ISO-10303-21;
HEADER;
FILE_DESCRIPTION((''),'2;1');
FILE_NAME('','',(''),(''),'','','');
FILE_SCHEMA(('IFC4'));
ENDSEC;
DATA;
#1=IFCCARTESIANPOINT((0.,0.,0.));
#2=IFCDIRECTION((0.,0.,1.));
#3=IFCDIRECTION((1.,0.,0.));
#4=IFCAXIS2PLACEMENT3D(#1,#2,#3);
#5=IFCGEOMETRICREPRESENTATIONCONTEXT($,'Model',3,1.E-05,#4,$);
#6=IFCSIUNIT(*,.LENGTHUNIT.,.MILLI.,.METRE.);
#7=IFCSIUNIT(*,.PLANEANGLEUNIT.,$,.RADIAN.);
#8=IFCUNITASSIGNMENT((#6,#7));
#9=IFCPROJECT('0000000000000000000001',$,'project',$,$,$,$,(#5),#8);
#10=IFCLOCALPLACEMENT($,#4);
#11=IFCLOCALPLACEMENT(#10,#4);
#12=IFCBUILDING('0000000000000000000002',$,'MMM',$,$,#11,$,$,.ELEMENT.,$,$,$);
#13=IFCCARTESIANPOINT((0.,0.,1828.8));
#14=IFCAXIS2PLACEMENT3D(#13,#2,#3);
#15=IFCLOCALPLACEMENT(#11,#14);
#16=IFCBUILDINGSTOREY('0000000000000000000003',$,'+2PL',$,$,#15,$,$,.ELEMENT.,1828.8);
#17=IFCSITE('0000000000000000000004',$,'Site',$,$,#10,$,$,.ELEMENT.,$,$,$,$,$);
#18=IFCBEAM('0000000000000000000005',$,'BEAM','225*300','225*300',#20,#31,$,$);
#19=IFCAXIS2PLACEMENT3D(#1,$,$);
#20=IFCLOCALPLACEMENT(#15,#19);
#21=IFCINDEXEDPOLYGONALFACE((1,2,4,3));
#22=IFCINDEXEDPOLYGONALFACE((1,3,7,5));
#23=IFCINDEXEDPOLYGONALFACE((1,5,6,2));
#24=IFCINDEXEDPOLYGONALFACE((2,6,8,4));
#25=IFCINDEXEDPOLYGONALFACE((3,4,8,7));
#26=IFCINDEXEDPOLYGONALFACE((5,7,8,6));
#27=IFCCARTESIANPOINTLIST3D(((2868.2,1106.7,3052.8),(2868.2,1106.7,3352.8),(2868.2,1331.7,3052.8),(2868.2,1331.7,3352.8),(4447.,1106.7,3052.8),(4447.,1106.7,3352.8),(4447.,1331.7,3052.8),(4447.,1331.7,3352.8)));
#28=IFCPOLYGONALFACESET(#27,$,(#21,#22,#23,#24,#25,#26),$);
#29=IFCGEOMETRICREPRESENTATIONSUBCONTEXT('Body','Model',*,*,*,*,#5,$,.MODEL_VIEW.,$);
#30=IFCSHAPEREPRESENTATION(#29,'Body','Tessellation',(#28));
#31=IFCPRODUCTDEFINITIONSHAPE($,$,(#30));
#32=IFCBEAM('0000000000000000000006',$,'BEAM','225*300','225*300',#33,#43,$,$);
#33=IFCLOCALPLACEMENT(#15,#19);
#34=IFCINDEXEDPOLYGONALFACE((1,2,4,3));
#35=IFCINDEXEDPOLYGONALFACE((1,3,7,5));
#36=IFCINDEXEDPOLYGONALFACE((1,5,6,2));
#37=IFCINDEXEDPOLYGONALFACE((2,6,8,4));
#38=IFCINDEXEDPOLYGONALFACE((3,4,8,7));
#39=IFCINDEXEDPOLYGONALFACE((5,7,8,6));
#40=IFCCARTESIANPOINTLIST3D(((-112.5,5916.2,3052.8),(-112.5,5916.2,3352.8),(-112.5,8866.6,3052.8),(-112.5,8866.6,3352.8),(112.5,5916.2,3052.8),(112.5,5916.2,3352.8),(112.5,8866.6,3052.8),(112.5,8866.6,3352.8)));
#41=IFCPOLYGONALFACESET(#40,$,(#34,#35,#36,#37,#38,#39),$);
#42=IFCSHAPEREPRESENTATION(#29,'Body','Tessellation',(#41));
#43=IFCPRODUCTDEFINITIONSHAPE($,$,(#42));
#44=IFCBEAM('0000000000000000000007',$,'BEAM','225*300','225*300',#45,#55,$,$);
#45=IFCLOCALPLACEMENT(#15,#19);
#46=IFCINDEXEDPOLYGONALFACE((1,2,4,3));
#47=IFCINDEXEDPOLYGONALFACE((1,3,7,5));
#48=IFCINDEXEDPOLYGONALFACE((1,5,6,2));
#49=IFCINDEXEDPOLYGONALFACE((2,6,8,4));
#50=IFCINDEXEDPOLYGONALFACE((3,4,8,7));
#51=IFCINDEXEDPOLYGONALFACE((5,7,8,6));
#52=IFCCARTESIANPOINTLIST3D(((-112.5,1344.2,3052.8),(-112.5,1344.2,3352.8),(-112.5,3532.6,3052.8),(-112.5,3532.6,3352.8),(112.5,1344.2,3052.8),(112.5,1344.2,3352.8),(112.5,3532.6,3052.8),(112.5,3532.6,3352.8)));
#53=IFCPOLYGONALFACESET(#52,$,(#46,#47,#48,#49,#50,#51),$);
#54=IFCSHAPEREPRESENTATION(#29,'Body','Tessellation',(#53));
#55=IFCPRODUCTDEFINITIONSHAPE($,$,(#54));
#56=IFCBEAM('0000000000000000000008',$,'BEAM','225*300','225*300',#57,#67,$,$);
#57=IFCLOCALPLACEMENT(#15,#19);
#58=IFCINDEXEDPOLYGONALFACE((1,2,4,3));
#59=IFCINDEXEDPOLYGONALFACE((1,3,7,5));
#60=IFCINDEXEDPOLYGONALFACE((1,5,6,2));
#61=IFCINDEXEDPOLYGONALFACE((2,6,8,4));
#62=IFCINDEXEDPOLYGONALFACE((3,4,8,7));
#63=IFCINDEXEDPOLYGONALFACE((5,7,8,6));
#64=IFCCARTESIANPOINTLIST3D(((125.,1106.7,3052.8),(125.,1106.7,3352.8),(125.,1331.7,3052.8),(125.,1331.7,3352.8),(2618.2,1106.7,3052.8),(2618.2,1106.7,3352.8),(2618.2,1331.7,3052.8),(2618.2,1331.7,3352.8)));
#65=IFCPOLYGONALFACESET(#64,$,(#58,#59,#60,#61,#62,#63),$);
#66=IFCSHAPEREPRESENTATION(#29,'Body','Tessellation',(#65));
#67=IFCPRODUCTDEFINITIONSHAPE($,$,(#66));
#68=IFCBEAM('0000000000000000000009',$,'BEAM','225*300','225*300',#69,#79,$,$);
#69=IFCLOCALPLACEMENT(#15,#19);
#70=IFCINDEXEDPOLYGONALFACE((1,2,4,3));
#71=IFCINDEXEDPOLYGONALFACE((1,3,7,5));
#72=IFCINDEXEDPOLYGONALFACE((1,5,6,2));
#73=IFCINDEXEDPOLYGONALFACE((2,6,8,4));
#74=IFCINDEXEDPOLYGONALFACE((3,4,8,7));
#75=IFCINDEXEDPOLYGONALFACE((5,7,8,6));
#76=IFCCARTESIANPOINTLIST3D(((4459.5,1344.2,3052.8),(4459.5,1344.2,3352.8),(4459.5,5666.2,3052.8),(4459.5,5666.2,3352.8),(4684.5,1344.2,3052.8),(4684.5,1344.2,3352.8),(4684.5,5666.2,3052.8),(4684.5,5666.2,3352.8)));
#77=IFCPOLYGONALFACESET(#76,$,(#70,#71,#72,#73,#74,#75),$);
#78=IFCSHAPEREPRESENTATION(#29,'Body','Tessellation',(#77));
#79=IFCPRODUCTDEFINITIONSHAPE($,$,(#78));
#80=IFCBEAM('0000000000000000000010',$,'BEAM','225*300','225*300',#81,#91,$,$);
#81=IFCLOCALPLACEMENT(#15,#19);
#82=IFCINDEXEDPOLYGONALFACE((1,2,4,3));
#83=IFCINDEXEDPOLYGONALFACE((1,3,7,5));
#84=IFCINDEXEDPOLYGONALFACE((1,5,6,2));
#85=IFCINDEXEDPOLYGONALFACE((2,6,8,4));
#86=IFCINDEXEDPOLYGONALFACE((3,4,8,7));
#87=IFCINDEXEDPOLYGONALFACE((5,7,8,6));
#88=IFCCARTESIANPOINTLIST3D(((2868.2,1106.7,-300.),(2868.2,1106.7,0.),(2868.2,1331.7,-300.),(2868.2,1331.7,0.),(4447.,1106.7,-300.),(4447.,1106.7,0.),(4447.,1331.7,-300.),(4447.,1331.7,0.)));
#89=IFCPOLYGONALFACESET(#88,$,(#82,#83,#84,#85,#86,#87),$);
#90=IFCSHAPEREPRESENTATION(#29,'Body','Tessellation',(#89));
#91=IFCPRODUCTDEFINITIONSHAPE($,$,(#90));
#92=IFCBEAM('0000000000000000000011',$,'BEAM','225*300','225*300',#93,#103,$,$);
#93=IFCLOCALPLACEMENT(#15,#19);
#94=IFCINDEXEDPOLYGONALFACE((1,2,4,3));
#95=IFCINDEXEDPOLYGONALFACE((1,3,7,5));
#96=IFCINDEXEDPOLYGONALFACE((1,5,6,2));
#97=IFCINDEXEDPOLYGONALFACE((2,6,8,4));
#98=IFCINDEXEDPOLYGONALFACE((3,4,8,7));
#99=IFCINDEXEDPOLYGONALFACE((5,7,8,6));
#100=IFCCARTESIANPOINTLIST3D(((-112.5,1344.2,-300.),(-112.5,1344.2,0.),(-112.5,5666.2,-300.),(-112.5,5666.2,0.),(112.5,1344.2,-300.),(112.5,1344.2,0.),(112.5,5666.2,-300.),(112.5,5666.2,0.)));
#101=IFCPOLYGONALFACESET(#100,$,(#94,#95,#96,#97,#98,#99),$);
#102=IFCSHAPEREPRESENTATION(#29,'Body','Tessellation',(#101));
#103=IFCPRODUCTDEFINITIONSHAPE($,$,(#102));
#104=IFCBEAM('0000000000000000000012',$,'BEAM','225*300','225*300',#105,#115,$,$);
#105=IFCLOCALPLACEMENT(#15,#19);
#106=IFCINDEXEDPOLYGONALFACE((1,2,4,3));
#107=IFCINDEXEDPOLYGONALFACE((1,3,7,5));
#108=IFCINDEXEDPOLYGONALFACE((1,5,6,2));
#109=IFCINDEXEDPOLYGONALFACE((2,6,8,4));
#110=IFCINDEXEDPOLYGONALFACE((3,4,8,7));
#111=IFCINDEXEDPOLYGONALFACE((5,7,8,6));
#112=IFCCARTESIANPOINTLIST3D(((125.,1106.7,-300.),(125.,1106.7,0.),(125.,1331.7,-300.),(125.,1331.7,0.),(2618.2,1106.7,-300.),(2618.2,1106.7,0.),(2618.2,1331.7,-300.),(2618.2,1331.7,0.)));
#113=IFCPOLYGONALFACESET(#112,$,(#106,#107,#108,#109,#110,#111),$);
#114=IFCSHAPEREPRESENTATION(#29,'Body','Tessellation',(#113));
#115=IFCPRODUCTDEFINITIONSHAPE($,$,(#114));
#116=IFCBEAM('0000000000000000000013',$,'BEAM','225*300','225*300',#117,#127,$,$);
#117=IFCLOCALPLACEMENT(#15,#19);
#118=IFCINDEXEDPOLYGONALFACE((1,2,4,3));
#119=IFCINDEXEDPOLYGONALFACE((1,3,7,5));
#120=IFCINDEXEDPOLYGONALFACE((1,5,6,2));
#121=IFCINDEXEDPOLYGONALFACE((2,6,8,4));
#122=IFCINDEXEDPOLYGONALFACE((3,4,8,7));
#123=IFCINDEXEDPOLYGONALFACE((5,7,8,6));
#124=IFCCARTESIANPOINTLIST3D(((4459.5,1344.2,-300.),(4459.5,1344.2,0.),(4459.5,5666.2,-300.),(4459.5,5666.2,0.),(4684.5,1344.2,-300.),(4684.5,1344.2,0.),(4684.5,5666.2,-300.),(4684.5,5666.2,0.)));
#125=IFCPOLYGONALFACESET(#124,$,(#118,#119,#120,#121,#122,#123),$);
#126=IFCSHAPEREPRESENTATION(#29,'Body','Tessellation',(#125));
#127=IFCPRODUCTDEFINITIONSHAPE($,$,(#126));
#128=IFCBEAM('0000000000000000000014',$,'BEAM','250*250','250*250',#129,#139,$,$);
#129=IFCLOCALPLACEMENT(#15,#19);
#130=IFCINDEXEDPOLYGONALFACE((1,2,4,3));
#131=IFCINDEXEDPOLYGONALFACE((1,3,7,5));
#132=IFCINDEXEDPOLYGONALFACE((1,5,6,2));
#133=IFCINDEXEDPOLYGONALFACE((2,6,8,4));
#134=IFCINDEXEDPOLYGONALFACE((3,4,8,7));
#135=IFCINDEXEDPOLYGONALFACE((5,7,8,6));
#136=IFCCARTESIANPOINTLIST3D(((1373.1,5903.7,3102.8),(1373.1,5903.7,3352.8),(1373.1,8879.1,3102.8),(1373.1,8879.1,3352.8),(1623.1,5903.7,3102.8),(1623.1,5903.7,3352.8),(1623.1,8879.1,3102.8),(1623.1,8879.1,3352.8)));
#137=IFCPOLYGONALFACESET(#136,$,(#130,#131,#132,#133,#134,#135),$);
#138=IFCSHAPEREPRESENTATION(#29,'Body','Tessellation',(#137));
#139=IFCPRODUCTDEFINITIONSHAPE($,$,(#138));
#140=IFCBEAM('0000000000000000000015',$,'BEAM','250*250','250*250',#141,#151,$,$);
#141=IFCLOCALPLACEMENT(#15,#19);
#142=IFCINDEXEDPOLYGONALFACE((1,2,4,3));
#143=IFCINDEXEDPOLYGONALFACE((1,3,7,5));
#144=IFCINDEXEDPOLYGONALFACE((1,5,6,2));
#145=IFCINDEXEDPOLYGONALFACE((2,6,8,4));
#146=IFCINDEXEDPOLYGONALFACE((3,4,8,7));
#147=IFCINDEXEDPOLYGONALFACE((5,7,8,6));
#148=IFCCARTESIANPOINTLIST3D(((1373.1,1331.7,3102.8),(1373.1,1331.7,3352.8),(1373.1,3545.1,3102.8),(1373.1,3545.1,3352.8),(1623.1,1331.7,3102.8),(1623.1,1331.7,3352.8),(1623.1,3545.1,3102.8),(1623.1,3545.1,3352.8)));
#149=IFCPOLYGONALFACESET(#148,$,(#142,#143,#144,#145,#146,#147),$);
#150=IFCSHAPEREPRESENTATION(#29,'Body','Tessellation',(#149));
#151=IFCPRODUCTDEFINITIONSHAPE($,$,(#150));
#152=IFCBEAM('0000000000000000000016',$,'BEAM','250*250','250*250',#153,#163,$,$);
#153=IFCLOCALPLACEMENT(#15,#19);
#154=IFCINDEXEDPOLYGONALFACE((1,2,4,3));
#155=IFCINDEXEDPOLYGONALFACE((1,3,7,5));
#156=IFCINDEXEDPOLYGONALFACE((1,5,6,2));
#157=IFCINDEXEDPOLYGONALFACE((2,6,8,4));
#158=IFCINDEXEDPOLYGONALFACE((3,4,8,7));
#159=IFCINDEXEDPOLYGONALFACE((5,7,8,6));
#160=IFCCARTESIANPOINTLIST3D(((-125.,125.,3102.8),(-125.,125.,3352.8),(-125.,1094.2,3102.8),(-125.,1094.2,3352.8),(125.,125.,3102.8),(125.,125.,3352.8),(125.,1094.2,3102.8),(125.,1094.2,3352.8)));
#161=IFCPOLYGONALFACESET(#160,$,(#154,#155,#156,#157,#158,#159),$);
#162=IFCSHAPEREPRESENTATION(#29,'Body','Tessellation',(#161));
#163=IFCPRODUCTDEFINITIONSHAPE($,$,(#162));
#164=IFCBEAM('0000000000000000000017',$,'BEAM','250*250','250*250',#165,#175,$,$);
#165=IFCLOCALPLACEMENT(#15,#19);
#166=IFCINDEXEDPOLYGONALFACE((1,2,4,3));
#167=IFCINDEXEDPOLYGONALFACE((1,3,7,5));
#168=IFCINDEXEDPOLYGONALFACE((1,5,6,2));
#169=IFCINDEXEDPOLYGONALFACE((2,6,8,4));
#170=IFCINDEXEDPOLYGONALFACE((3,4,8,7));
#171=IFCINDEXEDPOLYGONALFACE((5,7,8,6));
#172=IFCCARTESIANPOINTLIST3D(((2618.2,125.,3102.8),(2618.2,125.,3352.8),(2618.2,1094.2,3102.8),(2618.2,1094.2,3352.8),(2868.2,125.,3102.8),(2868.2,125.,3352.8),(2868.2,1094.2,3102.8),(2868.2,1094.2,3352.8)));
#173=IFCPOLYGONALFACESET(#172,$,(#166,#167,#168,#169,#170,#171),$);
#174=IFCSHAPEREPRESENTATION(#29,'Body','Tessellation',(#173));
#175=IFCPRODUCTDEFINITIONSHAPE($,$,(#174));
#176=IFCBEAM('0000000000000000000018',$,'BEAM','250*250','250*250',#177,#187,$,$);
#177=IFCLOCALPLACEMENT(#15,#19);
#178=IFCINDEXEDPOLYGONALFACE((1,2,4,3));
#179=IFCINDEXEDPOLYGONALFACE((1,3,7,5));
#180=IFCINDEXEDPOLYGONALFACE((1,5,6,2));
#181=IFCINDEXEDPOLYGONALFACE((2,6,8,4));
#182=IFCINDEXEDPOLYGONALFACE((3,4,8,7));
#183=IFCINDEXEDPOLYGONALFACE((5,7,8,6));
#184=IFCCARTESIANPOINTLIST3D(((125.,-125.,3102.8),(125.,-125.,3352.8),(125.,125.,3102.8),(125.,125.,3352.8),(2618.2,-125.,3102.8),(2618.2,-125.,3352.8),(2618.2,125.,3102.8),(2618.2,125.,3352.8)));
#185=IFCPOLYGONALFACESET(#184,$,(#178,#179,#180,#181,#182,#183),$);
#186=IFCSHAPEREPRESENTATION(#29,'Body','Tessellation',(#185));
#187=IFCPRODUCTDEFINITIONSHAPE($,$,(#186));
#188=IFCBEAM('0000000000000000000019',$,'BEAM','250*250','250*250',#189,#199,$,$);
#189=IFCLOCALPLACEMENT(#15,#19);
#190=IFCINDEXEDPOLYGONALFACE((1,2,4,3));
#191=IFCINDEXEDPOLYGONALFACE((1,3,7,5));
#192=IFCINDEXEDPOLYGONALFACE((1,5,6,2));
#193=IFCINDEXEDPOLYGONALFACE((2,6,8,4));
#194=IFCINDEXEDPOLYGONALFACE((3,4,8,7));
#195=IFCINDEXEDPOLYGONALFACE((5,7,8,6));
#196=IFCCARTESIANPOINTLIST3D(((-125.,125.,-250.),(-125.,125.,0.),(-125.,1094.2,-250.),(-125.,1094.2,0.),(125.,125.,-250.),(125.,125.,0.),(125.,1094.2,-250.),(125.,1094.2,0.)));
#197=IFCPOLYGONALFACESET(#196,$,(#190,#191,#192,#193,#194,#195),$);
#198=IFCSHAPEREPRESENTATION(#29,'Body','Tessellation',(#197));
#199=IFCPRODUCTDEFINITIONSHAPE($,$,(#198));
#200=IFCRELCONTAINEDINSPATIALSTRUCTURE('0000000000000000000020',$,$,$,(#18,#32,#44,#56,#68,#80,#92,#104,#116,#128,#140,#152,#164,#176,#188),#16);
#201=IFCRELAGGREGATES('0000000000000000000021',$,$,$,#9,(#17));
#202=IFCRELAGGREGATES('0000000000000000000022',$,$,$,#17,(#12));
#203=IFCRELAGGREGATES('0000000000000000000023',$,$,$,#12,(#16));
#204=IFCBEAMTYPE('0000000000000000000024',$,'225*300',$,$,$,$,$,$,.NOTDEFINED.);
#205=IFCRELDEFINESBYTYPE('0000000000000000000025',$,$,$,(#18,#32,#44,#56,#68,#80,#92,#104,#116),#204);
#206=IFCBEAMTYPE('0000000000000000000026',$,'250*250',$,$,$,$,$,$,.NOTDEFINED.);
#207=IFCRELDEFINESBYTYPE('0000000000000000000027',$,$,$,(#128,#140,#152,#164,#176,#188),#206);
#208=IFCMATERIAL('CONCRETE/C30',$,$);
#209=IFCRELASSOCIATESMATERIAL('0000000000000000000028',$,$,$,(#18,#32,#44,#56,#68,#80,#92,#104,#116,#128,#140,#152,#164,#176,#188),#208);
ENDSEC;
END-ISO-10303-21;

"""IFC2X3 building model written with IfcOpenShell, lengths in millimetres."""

from ifc_helpers import new_model, si_unit, frame, origin_with_axes, origin_2d_with_axis, place, context, subcontext, project, spatial, rectangle, extrude, material, type_object, element, save


model = new_model("IFC2X3")

# Units and contexts
model_context = context("Model", 3, precision=1e-05, world=origin_with_axes())
body_context = subcontext(model_context, "Body", "Model", "MODEL_VIEW")
ifc_project = project(units=[si_unit("LENGTHUNIT", "METRE", prefix="MILLI"), si_unit("PLANEANGLEUNIT", "RADIAN")], contexts=[model_context])

# Site, building, storey
site_placement = place(None, origin_with_axes())
site = spatial("IfcSite", under=ifc_project, at=site_placement, Name="Site", CompositionType="ELEMENT")
building_placement = place(site_placement, origin_with_axes())
building = spatial("IfcBuilding", under=site, at=building_placement, Name="MMM", CompositionType="ELEMENT")
storey_placement = place(building_placement, frame((0.0, 0.0, 1828.8), z_axis=(0.0, 0.0, 1.0), x_axis=(1.0, 0.0, 0.0)))
storey = spatial("IfcBuildingStorey", under=building, at=storey_placement, Name="+2PL", CompositionType="ELEMENT", Elevation=1828.8)

# Shared definitions
ifc_material = material(Name="CONCRETE/C30")

# Beams
beam_type_1 = type_object("IfcBeamType", Name="225*300", PredefinedType="NOTDEFINED")
beam_1_placement = place(storey_placement, frame((2868.2, 1219.2, 3202.8), z_axis=(0.0, 0.0, 1.0), x_axis=(1.0, 0.0, 0.0)))
element("IfcBeam", 1, at=beam_1_placement, inside=storey, type_object=beam_type_1, material=ifc_material, Name="BEAM", Description="225*300", ObjectType="225*300", context=body_context, shape_type="SweptSolid", body=[
    extrude(rectangle(XDim=225.0, YDim=300.0, at=origin_2d_with_axis()), frame((1578.8, 0.0, 0.0), z_axis=(-1.0, 0.0, 0.0), x_axis=(0.0, -1.0, 0.0)), (0.0, 0.0, 1.0), 1578.8),
])
beam_2_placement = place(storey_placement, frame((0.0, 5916.2, 3202.8), z_axis=(0.0, 0.0, 1.0), x_axis=(0.0, 1.0, 0.0)))
element("IfcBeam", 2, at=beam_2_placement, inside=storey, type_object=beam_type_1, material=ifc_material, Name="BEAM", Description="225*300", ObjectType="225*300", context=body_context, shape_type="SweptSolid", body=[
    extrude(rectangle(XDim=225.0, YDim=300.0, at=origin_2d_with_axis()), frame((2950.4, 0.0, 0.0), z_axis=(-1.0, 0.0, 0.0), x_axis=(0.0, -1.0, 0.0)), (0.0, 0.0, 1.0), 2950.4),
])
beam_3_placement = place(storey_placement, frame((0.0, 1344.2, 3202.8), z_axis=(0.0, 0.0, 1.0), x_axis=(0.0, 1.0, 0.0)))
element("IfcBeam", 3, at=beam_3_placement, inside=storey, type_object=beam_type_1, material=ifc_material, Name="BEAM", Description="225*300", ObjectType="225*300", context=body_context, shape_type="SweptSolid", body=[
    extrude(rectangle(XDim=225.0, YDim=300.0, at=origin_2d_with_axis()), frame((2188.4, 0.0, 0.0), z_axis=(-1.0, 0.0, 0.0), x_axis=(0.0, -1.0, 0.0)), (0.0, 0.0, 1.0), 2188.4),
])
beam_4_placement = place(storey_placement, frame((125.0, 1219.2, 3202.8), z_axis=(0.0, 0.0, 1.0), x_axis=(1.0, 0.0, 0.0)))
element("IfcBeam", 4, at=beam_4_placement, inside=storey, type_object=beam_type_1, material=ifc_material, Name="BEAM", Description="225*300", ObjectType="225*300", context=body_context, shape_type="SweptSolid", body=[
    extrude(rectangle(XDim=225.0, YDim=300.0, at=origin_2d_with_axis()), frame((2493.2, 0.0, 0.0), z_axis=(-1.0, 0.0, 0.0), x_axis=(0.0, -1.0, 0.0)), (0.0, 0.0, 1.0), 2493.2),
])
beam_5_placement = place(storey_placement, frame((4572.0, 1344.2, 3202.8), z_axis=(0.0, 0.0, 1.0), x_axis=(0.0, 1.0, 0.0)))
element("IfcBeam", 5, at=beam_5_placement, inside=storey, type_object=beam_type_1, material=ifc_material, Name="BEAM", Description="225*300", ObjectType="225*300", context=body_context, shape_type="SweptSolid", body=[
    extrude(rectangle(XDim=225.0, YDim=300.0, at=origin_2d_with_axis()), frame((4322.0, 0.0, 0.0), z_axis=(-1.0, 0.0, 0.0), x_axis=(0.0, -1.0, 0.0)), (0.0, 0.0, 1.0), 4322.0),
])
beam_6_placement = place(storey_placement, frame((2868.2, 1219.2, -150.0), z_axis=(0.0, 0.0, 1.0), x_axis=(1.0, 0.0, 0.0)))
element("IfcBeam", 6, at=beam_6_placement, inside=storey, type_object=beam_type_1, material=ifc_material, Name="BEAM", Description="225*300", ObjectType="225*300", context=body_context, shape_type="SweptSolid", body=[
    extrude(rectangle(XDim=225.0, YDim=300.0, at=origin_2d_with_axis()), frame((1578.8, 0.0, 0.0), z_axis=(-1.0, 0.0, 0.0), x_axis=(0.0, -1.0, 0.0)), (0.0, 0.0, 1.0), 1578.8),
])
beam_7_placement = place(storey_placement, frame((0.0, 1344.2, -150.0), z_axis=(0.0, 0.0, 1.0), x_axis=(0.0, 1.0, 0.0)))
element("IfcBeam", 7, at=beam_7_placement, inside=storey, type_object=beam_type_1, material=ifc_material, Name="BEAM", Description="225*300", ObjectType="225*300", context=body_context, shape_type="SweptSolid", body=[
    extrude(rectangle(XDim=225.0, YDim=300.0, at=origin_2d_with_axis()), frame((4322.0, 0.0, 0.0), z_axis=(-1.0, 0.0, 0.0), x_axis=(0.0, -1.0, 0.0)), (0.0, 0.0, 1.0), 4322.0),
])
beam_8_placement = place(storey_placement, frame((125.0, 1219.2, -150.0), z_axis=(0.0, 0.0, 1.0), x_axis=(1.0, 0.0, 0.0)))
element("IfcBeam", 8, at=beam_8_placement, inside=storey, type_object=beam_type_1, material=ifc_material, Name="BEAM", Description="225*300", ObjectType="225*300", context=body_context, shape_type="SweptSolid", body=[
    extrude(rectangle(XDim=225.0, YDim=300.0, at=origin_2d_with_axis()), frame((2493.2, 0.0, 0.0), z_axis=(-1.0, 0.0, 0.0), x_axis=(0.0, -1.0, 0.0)), (0.0, 0.0, 1.0), 2493.2),
])
beam_9_placement = place(storey_placement, frame((4572.0, 1344.2, -150.0), z_axis=(0.0, 0.0, 1.0), x_axis=(0.0, 1.0, 0.0)))
element("IfcBeam", 9, at=beam_9_placement, inside=storey, type_object=beam_type_1, material=ifc_material, Name="BEAM", Description="225*300", ObjectType="225*300", context=body_context, shape_type="SweptSolid", body=[
    extrude(rectangle(XDim=225.0, YDim=300.0, at=origin_2d_with_axis()), frame((4322.0, 0.0, 0.0), z_axis=(-1.0, 0.0, 0.0), x_axis=(0.0, -1.0, 0.0)), (0.0, 0.0, 1.0), 4322.0),
])
beam_type_2 = type_object("IfcBeamType", Name="250*250", PredefinedType="NOTDEFINED")
beam_10_placement = place(storey_placement, frame((1498.1, 5903.7, 3227.8), z_axis=(0.0, 0.0, 1.0), x_axis=(0.0, 1.0, 0.0)))
element("IfcBeam", 10, at=beam_10_placement, inside=storey, type_object=beam_type_2, material=ifc_material, Name="BEAM", Description="250*250", ObjectType="250*250", context=body_context, shape_type="SweptSolid", body=[
    extrude(rectangle(XDim=250.0, YDim=250.0, at=origin_2d_with_axis()), frame((2975.4, 0.0, 0.0), z_axis=(-1.0, 0.0, 0.0), x_axis=(0.0, -1.0, 0.0)), (0.0, 0.0, 1.0), 2975.4),
])
beam_11_placement = place(storey_placement, frame((1498.1, 1331.7, 3227.8), z_axis=(0.0, 0.0, 1.0), x_axis=(0.0, 1.0, 0.0)))
element("IfcBeam", 11, at=beam_11_placement, inside=storey, type_object=beam_type_2, material=ifc_material, Name="BEAM", Description="250*250", ObjectType="250*250", context=body_context, shape_type="SweptSolid", body=[
    extrude(rectangle(XDim=250.0, YDim=250.0, at=origin_2d_with_axis()), frame((2213.4, 0.0, 0.0), z_axis=(-1.0, 0.0, 0.0), x_axis=(0.0, -1.0, 0.0)), (0.0, 0.0, 1.0), 2213.4),
])
for number, where, z_axis, x_axis, name in (
    (12, (0.0, 125.0, 3227.8), (0.0, 0.0, 1.0), (0.0, 1.0, 0.0), "BEAM"),
    (13, (2743.2, 125.0, 3227.8), (0.0, 0.0, 1.0), (0.0, 1.0, 0.0), "BEAM"),
):
    element("IfcBeam", number, at=place(storey_placement, frame(where, z_axis=z_axis, x_axis=x_axis)), inside=storey, type_object=beam_type_2, material=ifc_material, Name=name, Description="250*250", ObjectType="250*250", context=body_context, shape_type="SweptSolid", body=[
        extrude(rectangle(XDim=250.0, YDim=250.0, at=origin_2d_with_axis()), frame((969.2, 0.0, 0.0), z_axis=(-1.0, 0.0, 0.0), x_axis=(0.0, -1.0, 0.0)), (0.0, 0.0, 1.0), 969.2),
    ])
beam_12_placement = place(storey_placement, frame((125.0, 0.0, 3227.8), z_axis=(0.0, 0.0, 1.0), x_axis=(1.0, 0.0, 0.0)))
element("IfcBeam", 14, at=beam_12_placement, inside=storey, type_object=beam_type_2, material=ifc_material, Name="BEAM", Description="250*250", ObjectType="250*250", context=body_context, shape_type="SweptSolid", body=[
    extrude(rectangle(XDim=250.0, YDim=250.0, at=origin_2d_with_axis()), frame((2493.2, 0.0, 0.0), z_axis=(-1.0, 0.0, 0.0), x_axis=(0.0, -1.0, 0.0)), (0.0, 0.0, 1.0), 2493.2),
])
for number, where, z_axis, x_axis, name in (
    (15, (0.0, 125.0, -125.0), (0.0, 0.0, 1.0), (0.0, 1.0, 0.0), "BEAM"),
):
    element("IfcBeam", number, at=place(storey_placement, frame(where, z_axis=z_axis, x_axis=x_axis)), inside=storey, type_object=beam_type_2, material=ifc_material, Name=name, Description="250*250", ObjectType="250*250", context=body_context, shape_type="SweptSolid", body=[
        extrude(rectangle(XDim=250.0, YDim=250.0, at=origin_2d_with_axis()), frame((969.2, 0.0, 0.0), z_axis=(-1.0, 0.0, 0.0), x_axis=(0.0, -1.0, 0.0)), (0.0, 0.0, 1.0), 969.2),
    ])

save(model, "model.ifc")
